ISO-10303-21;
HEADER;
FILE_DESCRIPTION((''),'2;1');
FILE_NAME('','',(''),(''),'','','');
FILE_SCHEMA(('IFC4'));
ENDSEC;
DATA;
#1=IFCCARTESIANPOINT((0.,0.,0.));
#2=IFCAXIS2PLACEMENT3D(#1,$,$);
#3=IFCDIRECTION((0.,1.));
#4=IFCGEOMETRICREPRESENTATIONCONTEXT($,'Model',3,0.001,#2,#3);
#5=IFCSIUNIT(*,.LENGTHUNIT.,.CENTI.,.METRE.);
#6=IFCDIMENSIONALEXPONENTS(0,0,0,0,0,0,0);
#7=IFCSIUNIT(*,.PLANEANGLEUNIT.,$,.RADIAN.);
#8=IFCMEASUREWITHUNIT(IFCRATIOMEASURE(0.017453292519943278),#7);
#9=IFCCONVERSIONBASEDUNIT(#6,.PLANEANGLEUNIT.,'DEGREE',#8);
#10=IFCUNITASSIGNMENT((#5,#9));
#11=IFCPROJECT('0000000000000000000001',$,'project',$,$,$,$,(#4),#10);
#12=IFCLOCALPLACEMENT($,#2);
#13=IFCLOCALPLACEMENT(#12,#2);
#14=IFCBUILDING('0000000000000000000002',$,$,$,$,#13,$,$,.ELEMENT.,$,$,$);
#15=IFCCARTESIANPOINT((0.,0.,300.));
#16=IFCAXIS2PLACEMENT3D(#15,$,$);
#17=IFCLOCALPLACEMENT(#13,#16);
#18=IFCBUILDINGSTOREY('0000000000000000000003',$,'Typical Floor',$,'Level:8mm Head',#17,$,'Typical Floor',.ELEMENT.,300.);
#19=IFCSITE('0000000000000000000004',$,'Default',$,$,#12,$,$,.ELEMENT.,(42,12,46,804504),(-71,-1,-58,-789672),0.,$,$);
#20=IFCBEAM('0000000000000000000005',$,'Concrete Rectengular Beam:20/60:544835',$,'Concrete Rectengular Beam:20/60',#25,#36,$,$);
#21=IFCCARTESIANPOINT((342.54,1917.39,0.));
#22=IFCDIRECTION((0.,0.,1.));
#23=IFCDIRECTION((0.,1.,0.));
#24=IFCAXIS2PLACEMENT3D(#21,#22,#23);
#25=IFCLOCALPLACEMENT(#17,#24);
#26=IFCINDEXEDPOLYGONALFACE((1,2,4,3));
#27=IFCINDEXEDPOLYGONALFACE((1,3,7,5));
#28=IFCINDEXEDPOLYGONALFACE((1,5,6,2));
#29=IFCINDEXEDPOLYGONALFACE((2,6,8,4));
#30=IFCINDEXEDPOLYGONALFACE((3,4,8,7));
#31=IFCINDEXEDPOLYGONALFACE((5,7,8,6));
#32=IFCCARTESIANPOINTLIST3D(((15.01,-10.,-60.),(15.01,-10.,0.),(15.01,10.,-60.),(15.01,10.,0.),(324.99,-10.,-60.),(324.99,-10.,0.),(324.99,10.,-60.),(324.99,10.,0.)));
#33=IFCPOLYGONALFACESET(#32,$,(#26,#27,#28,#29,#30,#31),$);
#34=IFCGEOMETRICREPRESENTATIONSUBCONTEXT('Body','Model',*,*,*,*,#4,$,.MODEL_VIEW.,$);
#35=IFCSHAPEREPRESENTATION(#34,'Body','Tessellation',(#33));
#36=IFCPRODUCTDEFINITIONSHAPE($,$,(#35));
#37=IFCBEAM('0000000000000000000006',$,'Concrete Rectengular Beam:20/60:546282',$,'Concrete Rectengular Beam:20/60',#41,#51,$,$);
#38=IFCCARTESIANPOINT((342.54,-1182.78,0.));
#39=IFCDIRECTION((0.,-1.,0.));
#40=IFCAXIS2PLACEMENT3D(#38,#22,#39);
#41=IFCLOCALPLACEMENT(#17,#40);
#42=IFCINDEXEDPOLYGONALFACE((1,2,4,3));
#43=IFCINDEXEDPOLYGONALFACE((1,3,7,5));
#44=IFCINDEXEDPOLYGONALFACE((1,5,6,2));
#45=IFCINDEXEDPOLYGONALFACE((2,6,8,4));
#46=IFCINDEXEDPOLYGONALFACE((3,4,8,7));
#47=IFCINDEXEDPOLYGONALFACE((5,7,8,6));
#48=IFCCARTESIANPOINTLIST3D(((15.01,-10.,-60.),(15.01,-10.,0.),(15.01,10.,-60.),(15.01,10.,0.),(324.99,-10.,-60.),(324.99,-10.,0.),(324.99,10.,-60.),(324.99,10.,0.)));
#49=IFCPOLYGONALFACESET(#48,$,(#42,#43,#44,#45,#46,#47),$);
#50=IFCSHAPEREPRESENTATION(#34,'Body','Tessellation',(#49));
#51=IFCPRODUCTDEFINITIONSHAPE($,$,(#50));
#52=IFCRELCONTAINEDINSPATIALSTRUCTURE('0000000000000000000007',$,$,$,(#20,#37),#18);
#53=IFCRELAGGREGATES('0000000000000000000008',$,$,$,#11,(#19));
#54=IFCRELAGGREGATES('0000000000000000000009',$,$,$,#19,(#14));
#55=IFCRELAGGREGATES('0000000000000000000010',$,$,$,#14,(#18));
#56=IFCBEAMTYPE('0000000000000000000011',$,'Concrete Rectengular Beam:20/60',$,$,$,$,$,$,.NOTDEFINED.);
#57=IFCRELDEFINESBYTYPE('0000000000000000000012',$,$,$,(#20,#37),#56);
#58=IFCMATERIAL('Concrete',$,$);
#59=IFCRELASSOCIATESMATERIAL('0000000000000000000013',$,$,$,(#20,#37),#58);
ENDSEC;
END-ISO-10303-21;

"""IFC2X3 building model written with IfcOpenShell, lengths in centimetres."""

from ifc_helpers import new_model, entity, si_unit, converted_unit, direction, frame, origin, origin_2d_with_axis, place, context, subcontext, project, spatial, rectangle, extrude, material, type_object, element, save


model = new_model("IFC2X3")

# Units and contexts
model_context = context("Model", 3, precision=0.001, world=origin(), true_north=direction((0.0, 1.0)))
body_context = subcontext(model_context, "Body", "Model", "MODEL_VIEW")
ifc_project = project(units=[si_unit("LENGTHUNIT", "METRE", prefix="CENTI"), converted_unit("PLANEANGLEUNIT", "DEGREE", entity("IfcRatioMeasure", 0.017453292519943278), si_unit("PLANEANGLEUNIT", "RADIAN"), dimensions=[0, 0, 0, 0, 0, 0, 0])], contexts=[model_context])

# Site, building, storey
site_placement = place(None, origin())
site = spatial("IfcSite", under=ifc_project, at=site_placement, Name="Default", CompositionType="ELEMENT", RefLatitude=(42, 12, 46, 804504), RefLongitude=(-71, -1, -58, -789672), RefElevation=0.0)
building_placement = place(site_placement, origin())
building = spatial("IfcBuilding", under=site, at=building_placement, CompositionType="ELEMENT")
storey_placement = place(building_placement, frame((0.0, 0.0, 300.0)))
storey = spatial("IfcBuildingStorey", under=building, at=storey_placement, Name="Typical Floor", ObjectType="Level:8mm Head", LongName="Typical Floor", CompositionType="ELEMENT", Elevation=300.0)

# Beams
ifc_material = material(Name="Concrete")
beam_type = type_object("IfcBeamType", Name="Concrete Rectengular Beam:20/60", PredefinedType="NOTDEFINED")
beam_1_placement = place(storey_placement, frame((342.54, 1917.39, 0.0), z_axis=(0.0, 0.0, 1.0), x_axis=(0.0, 1.0, 0.0)))
element("IfcBeam", 1, at=beam_1_placement, inside=storey, type_object=beam_type, material=ifc_material, Name="Concrete Rectengular Beam:20/60:544835", ObjectType="Concrete Rectengular Beam:20/60", context=body_context, shape_type="SweptSolid", body=[
    extrude(rectangle(XDim=60.0, YDim=20.0, at=origin_2d_with_axis()), frame((15.01, 0.0, -30.0), z_axis=(1.0, 0.0, 0.0), x_axis=(0.0, 0.0, -1.0)), (0.0, 0.0, 1.0), 309.98),
])
beam_2_placement = place(storey_placement, frame((342.54, -1182.78, 0.0), z_axis=(0.0, 0.0, 1.0), x_axis=(0.0, -1.0, 0.0)))
element("IfcBeam", 2, at=beam_2_placement, inside=storey, type_object=beam_type, material=ifc_material, Name="Concrete Rectengular Beam:20/60:546282", ObjectType="Concrete Rectengular Beam:20/60", context=body_context, shape_type="SweptSolid", body=[
    extrude(rectangle(XDim=60.0, YDim=20.0, at=origin_2d_with_axis()), frame((15.01, 0.0, -30.0), z_axis=(1.0, 0.0, 0.0), x_axis=(0.0, 0.0, -1.0)), (0.0, 0.0, 1.0), 309.98),
])

save(model, "model.ifc")
